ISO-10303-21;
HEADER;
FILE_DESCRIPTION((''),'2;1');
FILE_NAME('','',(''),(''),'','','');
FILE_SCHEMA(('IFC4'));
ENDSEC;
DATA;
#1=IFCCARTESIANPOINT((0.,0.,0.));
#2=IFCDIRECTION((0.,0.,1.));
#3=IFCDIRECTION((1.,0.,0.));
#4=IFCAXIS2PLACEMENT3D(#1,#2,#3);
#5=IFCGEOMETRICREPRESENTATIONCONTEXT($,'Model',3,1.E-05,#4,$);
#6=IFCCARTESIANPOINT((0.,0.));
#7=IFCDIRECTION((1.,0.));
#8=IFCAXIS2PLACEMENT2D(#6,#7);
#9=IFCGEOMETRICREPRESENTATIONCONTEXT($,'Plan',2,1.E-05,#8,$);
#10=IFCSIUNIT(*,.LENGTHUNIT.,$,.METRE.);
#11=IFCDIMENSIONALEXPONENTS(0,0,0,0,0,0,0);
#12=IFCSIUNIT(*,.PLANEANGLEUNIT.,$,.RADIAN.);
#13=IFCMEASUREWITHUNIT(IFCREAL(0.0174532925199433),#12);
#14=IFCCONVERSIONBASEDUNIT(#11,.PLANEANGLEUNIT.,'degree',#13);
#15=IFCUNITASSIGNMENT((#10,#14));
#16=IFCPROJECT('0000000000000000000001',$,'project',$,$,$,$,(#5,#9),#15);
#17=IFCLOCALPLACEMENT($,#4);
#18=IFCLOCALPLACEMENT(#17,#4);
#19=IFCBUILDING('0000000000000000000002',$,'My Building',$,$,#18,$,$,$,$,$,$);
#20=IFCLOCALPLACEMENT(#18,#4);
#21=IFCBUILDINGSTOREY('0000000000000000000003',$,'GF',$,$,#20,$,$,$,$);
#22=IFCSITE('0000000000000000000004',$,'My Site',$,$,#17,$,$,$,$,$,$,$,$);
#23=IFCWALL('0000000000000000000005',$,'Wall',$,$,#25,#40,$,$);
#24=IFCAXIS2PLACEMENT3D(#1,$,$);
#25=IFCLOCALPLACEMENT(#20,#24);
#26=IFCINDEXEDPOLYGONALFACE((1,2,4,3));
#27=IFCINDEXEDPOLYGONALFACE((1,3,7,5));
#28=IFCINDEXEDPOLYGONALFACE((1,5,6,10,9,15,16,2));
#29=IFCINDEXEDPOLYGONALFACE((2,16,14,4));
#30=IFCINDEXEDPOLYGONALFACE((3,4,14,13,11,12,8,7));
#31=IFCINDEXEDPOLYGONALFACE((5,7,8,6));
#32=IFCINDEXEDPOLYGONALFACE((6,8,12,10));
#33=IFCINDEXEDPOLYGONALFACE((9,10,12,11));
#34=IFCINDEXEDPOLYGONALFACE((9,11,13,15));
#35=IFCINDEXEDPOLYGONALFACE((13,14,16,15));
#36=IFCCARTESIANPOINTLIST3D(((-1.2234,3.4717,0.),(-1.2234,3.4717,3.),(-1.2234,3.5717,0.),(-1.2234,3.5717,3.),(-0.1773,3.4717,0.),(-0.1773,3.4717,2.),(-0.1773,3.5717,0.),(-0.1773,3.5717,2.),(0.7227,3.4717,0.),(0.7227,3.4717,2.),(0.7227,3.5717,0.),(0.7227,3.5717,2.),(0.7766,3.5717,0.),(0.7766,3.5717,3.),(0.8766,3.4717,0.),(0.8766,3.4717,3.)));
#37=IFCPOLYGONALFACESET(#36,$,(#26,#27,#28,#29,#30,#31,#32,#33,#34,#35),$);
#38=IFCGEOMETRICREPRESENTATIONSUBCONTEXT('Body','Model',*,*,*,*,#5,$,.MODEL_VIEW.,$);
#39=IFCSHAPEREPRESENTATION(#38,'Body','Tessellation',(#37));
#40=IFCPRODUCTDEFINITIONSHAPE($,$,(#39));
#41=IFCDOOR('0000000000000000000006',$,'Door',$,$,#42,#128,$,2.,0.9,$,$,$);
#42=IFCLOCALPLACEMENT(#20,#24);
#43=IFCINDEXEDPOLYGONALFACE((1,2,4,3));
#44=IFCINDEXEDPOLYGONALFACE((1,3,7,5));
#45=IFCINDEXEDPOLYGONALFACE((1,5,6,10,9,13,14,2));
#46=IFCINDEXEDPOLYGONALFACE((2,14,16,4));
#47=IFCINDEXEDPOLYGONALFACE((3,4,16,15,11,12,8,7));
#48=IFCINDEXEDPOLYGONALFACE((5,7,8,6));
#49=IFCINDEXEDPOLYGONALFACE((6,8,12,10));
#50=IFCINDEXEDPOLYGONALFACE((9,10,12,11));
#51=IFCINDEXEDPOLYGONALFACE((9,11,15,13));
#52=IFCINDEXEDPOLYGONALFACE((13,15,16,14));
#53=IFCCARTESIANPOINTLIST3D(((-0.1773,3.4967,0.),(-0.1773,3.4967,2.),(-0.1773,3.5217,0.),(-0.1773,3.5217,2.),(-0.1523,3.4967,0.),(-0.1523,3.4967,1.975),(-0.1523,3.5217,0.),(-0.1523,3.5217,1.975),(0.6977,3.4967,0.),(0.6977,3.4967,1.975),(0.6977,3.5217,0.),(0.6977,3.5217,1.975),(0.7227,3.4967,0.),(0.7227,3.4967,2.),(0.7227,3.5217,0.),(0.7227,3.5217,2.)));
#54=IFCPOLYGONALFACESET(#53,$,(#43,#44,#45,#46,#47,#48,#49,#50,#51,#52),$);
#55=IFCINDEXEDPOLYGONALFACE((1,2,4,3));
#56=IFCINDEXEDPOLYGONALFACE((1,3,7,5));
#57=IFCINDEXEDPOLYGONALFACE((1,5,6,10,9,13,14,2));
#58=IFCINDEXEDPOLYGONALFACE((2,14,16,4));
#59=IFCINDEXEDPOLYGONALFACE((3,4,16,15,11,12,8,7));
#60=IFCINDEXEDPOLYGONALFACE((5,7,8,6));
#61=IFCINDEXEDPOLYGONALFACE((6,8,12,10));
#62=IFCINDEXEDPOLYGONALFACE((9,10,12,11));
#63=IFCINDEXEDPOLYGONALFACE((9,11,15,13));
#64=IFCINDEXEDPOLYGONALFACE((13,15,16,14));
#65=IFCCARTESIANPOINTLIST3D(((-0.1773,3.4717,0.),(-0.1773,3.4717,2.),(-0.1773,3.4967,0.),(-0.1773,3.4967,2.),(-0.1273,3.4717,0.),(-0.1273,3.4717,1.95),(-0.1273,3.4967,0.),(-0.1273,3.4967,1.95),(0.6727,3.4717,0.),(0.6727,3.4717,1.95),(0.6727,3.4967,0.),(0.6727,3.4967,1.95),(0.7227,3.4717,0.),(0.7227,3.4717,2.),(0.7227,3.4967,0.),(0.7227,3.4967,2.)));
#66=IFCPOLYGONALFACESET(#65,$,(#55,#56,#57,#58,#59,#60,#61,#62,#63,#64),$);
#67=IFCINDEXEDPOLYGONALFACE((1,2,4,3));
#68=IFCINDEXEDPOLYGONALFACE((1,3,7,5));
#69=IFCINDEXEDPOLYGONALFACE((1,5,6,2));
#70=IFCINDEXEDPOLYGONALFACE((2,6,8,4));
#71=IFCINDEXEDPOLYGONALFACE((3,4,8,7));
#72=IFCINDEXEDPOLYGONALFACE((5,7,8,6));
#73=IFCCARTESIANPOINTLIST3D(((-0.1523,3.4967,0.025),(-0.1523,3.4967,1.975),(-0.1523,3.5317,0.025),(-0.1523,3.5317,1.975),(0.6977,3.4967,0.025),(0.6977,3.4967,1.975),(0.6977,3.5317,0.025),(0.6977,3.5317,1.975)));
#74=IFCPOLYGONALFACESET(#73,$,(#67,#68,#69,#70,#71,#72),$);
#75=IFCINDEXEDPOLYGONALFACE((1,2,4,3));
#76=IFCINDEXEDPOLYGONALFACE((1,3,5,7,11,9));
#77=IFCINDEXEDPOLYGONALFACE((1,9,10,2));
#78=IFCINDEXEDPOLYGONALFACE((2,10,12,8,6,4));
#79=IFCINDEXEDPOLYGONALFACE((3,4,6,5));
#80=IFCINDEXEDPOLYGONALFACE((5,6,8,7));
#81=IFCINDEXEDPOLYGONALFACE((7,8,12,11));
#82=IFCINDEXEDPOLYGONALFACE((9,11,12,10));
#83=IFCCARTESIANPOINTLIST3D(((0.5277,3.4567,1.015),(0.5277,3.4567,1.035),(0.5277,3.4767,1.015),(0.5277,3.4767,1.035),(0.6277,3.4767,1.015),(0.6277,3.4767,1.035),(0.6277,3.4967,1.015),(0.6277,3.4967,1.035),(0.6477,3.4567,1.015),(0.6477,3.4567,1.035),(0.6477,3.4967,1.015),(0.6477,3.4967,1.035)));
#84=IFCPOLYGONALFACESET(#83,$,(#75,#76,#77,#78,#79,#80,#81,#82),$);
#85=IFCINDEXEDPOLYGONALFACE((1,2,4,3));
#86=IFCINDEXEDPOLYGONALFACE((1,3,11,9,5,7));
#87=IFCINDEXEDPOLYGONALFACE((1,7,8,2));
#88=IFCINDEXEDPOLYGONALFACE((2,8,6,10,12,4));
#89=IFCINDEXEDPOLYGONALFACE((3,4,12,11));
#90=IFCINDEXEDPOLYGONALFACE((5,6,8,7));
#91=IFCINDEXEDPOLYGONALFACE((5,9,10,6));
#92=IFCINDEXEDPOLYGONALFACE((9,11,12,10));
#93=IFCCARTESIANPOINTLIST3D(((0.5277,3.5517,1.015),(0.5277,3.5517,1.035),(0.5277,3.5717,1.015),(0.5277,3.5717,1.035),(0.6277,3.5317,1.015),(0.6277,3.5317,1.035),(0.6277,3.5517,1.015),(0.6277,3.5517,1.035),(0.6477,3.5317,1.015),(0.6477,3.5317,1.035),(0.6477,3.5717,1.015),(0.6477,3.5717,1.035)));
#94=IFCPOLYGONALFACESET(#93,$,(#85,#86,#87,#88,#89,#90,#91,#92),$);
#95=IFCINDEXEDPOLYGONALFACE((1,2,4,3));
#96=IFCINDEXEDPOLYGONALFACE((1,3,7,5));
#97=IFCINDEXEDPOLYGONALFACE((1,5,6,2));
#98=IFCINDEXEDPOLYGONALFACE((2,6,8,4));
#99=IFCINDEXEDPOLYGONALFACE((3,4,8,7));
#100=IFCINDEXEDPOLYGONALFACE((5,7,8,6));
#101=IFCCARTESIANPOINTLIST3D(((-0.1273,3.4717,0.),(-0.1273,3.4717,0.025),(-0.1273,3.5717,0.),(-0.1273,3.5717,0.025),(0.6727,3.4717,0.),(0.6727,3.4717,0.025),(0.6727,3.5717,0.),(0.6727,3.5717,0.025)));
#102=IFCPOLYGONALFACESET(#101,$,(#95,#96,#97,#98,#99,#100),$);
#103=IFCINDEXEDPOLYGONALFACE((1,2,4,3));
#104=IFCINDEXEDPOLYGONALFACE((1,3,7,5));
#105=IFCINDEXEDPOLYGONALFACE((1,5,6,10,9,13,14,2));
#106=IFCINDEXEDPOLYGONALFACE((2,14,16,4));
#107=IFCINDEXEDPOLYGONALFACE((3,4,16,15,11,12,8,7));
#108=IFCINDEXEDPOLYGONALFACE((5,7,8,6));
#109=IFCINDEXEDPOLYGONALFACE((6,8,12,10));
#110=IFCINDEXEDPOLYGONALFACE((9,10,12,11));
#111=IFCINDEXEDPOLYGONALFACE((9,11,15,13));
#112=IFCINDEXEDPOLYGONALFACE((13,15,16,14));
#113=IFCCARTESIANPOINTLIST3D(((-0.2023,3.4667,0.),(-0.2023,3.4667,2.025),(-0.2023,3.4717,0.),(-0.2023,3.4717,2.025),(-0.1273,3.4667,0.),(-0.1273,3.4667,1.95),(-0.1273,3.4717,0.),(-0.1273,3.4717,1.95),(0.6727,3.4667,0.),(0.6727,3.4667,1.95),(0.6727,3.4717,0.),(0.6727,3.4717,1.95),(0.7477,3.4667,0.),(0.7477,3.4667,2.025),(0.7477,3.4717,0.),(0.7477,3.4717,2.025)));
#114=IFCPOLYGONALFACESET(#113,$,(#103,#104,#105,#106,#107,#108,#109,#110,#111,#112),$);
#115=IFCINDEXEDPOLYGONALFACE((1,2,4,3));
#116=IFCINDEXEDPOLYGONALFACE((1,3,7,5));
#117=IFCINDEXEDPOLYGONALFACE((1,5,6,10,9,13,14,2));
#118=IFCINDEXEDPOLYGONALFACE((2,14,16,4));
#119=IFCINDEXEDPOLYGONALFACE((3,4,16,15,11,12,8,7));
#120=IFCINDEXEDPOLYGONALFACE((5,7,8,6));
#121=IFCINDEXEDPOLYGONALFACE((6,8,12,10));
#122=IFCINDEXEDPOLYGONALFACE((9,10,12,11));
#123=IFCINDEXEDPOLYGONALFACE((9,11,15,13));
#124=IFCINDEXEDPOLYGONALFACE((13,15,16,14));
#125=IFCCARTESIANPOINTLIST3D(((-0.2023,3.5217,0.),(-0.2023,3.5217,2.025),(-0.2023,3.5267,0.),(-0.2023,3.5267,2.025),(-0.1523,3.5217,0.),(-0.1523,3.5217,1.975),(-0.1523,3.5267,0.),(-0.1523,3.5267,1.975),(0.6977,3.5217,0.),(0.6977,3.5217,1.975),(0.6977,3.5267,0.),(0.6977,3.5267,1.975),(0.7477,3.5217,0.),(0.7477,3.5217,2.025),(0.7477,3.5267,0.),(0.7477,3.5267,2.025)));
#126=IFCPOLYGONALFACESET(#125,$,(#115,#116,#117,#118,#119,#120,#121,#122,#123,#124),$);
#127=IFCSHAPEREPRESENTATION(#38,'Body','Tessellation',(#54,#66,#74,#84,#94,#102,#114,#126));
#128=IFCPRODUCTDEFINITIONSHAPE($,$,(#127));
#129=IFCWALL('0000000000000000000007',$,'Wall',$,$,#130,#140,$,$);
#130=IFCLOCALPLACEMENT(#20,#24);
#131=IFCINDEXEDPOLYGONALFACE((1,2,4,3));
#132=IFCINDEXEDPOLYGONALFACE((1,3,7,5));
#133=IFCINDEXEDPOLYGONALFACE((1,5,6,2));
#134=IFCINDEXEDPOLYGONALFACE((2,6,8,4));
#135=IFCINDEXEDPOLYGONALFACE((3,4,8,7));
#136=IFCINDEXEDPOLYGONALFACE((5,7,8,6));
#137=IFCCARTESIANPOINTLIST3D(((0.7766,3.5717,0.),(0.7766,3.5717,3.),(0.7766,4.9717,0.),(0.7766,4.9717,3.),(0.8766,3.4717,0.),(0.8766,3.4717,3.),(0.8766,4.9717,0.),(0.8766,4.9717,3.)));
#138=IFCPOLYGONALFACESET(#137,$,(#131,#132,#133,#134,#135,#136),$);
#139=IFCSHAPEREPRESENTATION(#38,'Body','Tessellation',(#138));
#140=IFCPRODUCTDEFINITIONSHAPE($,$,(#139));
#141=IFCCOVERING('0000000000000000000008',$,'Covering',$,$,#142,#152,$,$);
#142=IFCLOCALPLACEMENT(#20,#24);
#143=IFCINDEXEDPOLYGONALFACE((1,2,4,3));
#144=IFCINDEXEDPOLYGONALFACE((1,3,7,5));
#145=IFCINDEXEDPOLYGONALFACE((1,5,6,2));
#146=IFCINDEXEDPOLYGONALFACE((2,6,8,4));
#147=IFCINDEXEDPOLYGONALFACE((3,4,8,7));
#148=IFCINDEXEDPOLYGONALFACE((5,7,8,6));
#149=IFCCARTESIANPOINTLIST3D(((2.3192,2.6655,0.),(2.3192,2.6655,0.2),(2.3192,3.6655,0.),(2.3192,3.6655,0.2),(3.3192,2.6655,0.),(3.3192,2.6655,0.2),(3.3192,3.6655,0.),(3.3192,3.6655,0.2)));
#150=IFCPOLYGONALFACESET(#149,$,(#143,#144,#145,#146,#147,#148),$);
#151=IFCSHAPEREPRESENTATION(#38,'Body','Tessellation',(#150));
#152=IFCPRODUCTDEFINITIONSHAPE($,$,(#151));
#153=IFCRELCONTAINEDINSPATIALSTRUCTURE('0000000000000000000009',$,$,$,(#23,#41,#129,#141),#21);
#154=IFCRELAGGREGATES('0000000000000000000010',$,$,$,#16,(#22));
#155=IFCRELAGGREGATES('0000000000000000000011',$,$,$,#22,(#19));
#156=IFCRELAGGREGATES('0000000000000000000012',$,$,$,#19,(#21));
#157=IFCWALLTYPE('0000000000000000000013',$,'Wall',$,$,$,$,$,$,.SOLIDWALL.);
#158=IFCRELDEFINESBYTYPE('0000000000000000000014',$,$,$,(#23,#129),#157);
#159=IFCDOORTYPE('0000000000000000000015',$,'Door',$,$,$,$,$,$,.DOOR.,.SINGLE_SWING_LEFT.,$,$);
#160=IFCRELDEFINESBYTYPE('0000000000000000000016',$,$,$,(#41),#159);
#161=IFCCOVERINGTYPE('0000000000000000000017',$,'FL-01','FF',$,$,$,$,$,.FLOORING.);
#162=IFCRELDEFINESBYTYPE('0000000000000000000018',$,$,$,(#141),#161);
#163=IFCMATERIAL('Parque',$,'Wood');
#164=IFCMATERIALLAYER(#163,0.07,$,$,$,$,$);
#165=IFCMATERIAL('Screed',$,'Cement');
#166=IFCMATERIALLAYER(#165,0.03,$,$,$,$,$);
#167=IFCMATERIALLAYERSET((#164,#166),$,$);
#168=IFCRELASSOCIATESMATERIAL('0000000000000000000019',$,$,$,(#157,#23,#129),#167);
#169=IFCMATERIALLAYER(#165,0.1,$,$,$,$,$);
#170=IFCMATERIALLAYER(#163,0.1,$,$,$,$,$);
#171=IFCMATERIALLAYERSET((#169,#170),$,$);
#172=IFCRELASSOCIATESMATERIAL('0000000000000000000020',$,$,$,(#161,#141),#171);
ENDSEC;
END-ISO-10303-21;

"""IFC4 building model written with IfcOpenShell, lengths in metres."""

from ifc_helpers import new_model, entity, si_unit, converted_unit, frame, origin_with_axes, origin_2d_with_axis, place, context, subcontext, project, spatial, line, indexed_curve, outline, extrude, shape, source, transform, mapped, material, layer, layer_set, layer_usage, type_object, type_shapes, element, fill, save


model = new_model("IFC4")

# Units and contexts
model_context = context("Model", 3, precision=1e-05, world=origin_with_axes())
plan_context = context("Plan", 2, precision=1e-05, world=origin_2d_with_axis())
body_context_1 = subcontext(model_context, "Body", "Model", "MODEL_VIEW")
body_context_2 = subcontext(plan_context, "Body", "Plan", "PLAN_VIEW")
ifc_project = project(units=[si_unit("LENGTHUNIT", "METRE"), converted_unit("PLANEANGLEUNIT", "degree", entity("IfcReal", 0.0174532925199433), si_unit("PLANEANGLEUNIT", "RADIAN"), dimensions=[0, 0, 0, 0, 0, 0, 0])], contexts=[model_context, plan_context])

# Site, building, storey
site_placement = place(None, origin_with_axes())
site = spatial("IfcSite", under=ifc_project, at=site_placement, Name="My Site")
building_placement = place(site_placement, origin_with_axes())
building = spatial("IfcBuilding", under=site, at=building_placement, Name="My Building")
storey_placement = place(building_placement, origin_with_axes())
storey = spatial("IfcBuildingStorey", under=building, at=storey_placement, Name="GF")

# Shared definitions
ifc_material_1 = material(Name="Parque", Category="Wood")
ifc_layer_1 = layer(ifc_material_1, 0.07)
ifc_material_2 = material(Name="Screed", Category="Cement")
ifc_layer_2 = layer(ifc_material_2, 0.03)
ifc_layer_set_1 = layer_set([ifc_layer_1, ifc_layer_2])
wall_type = type_object("IfcWallType", Name="Wall", PredefinedType="SOLIDWALL", material=ifc_layer_set_1)

# Shared definitions
shared_shape_1 = source(origin_with_axes(), body_context_1, "Body", "SweptSolid", [
    extrude(outline(indexed_curve([(0.0, 0.0), (0.9, 0.0), (0.9, 2.0), (0.0, 2.0)], segments=[line(1, 2, 3, 4, 1)])), frame((0.0, -0.6, 0.0), z_axis=(0.0, -1.0, 0.0), x_axis=(1.0, 0.0, 0.0)), (0.0, 0.0, -1.0), 1.2),
])
door_type = type_object("IfcDoorType", Name="Door", OperationType="SINGLE_SWING_LEFT", PredefinedType="DOOR")
shared_shape_2 = source(origin_with_axes(), body_context_1, "Body", "SweptSolid", [
    extrude(outline(indexed_curve([(0.0, 0.0), (0.0, 2.0), (0.9, 2.0), (0.9, 0.0), (0.875, 0.0), (0.875, 1.975), (0.025, 1.975), (0.025, 0.0)], segments=[line(1, 2, 3, 4, 5, 6, 7, 8, 1)])), frame((0.0, 0.025, 0.0), z_axis=(0.0, -1.0, 0.0), x_axis=(1.0, 0.0, 0.0)), (0.0, 0.0, -1.0), 0.025),
    extrude(outline(indexed_curve([(0.0, 0.0), (0.0, 2.0), (0.9, 2.0), (0.9, 0.0), (0.85, 0.0), (0.85, 1.95), (0.05, 1.95), (0.05, 0.0)], segments=[line(1, 2, 3, 4, 5, 6, 7, 8, 1)])), frame((0.0, 0.0, 0.0), z_axis=(0.0, -1.0, 0.0), x_axis=(1.0, 0.0, 0.0)), (0.0, 0.0, -1.0), 0.025),
    extrude(outline(indexed_curve([(0.0, 0.0), (0.85, 0.0), (0.85, 0.035), (0.0, 0.035)], segments=[line(1, 2, 3, 4, 1)])), frame((0.025, 0.025, 0.025), z_axis=(0.0, 0.0, 1.0), x_axis=(1.0, 0.0, 0.0)), (0.0, 0.0, 1.0), 1.95),
    extrude(outline(indexed_curve([(0.0, 0.0), (0.0, -0.04), (-0.12, -0.04), (-0.12, -0.02), (-0.02, -0.02), (-0.02, 0.0)], segments=[line(1, 2, 3, 4, 5, 6, 1)])), frame((0.825, 0.025, 1.015), z_axis=(0.0, 0.0, 1.0), x_axis=(1.0, 0.0, 0.0)), (0.0, 0.0, 1.0), 0.02),
    extrude(outline(indexed_curve([(0.0, 0.0), (0.0, 0.04), (-0.12, 0.04), (-0.12, 0.02), (-0.02, 0.02), (-0.02, 0.0)], segments=[line(1, 2, 3, 4, 5, 6, 1)])), frame((0.825, 0.06, 1.015), z_axis=(0.0, 0.0, 1.0), x_axis=(1.0, 0.0, 0.0)), (0.0, 0.0, 1.0), 0.02),
    extrude(outline(indexed_curve([(0.0, 0.0), (0.8, 0.0), (0.8, 0.1), (0.0, 0.1)], segments=[line(1, 2, 3, 4, 1)])), frame((0.05, 0.0, 0.0), z_axis=(0.0, 0.0, 1.0), x_axis=(1.0, 0.0, 0.0)), (0.0, 0.0, 1.0), 0.025),
    extrude(outline(indexed_curve([(0.0, 0.0), (0.0, 2.025), (0.95, 2.025), (0.95, 0.0), (0.875, 0.0), (0.875, 1.95), (0.075, 1.95), (0.075, 0.0)], segments=[line(1, 2, 3, 4, 5, 6, 7, 8, 1)])), frame((-0.025, -0.005, 0.0), z_axis=(0.0, -1.0, 0.0), x_axis=(1.0, 0.0, 0.0)), (0.0, 0.0, -1.0), 0.005),
    extrude(outline(indexed_curve([(0.0, 0.0), (0.0, 2.025), (0.95, 2.025), (0.95, 0.0), (0.9, 0.0), (0.9, 1.975), (0.05, 1.975), (0.05, 0.0)], segments=[line(1, 2, 3, 4, 5, 6, 7, 8, 1)])), frame((-0.025, 0.05, 0.0), z_axis=(0.0, -1.0, 0.0), x_axis=(1.0, 0.0, 0.0)), (0.0, 0.0, -1.0), 0.005),
])
shared_shape_3 = source(origin_with_axes(), body_context_2, "Body", "Curve2D", [
    entity("IfcIndexedPolyCurve", entity("IfcCartesianPointList2D", [[0.0, 0.0], [0.0, 0.05], [0.025, 0.05], [0.025, 0.025], [0.05, 0.025], [0.05, 0.0]]), [entity("IfcLineIndex", [1, 2, 3, 4, 5, 6, 1])]),
    entity("IfcIndexedPolyCurve", entity("IfcCartesianPointList2D", [[0.9, 0.0], [0.9, 0.05], [0.875, 0.05], [0.875, 0.025], [0.85, 0.025], [0.85, 0.0]]), [entity("IfcLineIndex", [1, 2, 3, 4, 5, 6, 1])]),
    entity("IfcTrimmedCurve", entity("IfcEllipse", entity("IfcAxis2Placement2D", entity("IfcCartesianPoint", [0.06, 0.05]), entity("IfcDirection", [1.0, 0.0])), 0.815, 0.85), [entity("IfcCartesianPoint", [0.875, 0.05])], [entity("IfcCartesianPoint", [0.06, 0.9])], True, "CARTESIAN"),
    entity("IfcIndexedPolyCurve", entity("IfcCartesianPointList2D", [[0.025, 0.05], [0.06, 0.05], [0.06, 0.9], [0.025, 0.9]]), [entity("IfcLineIndex", [1, 2, 3, 4, 1])]),
])
type_shapes(door_type, [shared_shape_2, shared_shape_3])

# Wall, opening, door
ifc_layer_usage_1 = layer_usage(ifc_layer_set_1, "AXIS2", "POSITIVE", 0.0)
wall_1_placement = place(storey_placement, frame((-1.2234, 3.4717, 0.0), z_axis=(0.0, 0.0, 1.0), x_axis=(1.0, 0.0, 0.0)))
wall_1 = element("IfcWall", 1, at=wall_1_placement, inside=storey, type_object=wall_type, material=ifc_layer_usage_1, Name="Wall", context=body_context_1, shape_type="SweptSolid", body=[
    extrude(outline(indexed_curve([(0.0, 0.0), (0.0, 0.1), (2.0, 0.1), (2.1, 0.0)], segments=[line(1, 2, 3, 4, 1)])), origin_with_axes(), (0.0, 0.0, 1.0), 3.0),
])
opening_1_placement = place(wall_1_placement, frame((1.046, 0.0, 0.0), z_axis=(0.0, 0.0, 1.0), x_axis=(1.0, 0.0, 0.0)))
opening_1 = element("IfcOpeningElement", 2, at=opening_1_placement, cuts=wall_1, PredefinedType="OPENING", context=body_context_1, shape_type="MappedRepresentation", body=[
    mapped(shared_shape_1, transform((0.0, 0.0, 0.0), x_axis=(1.0, 0.0, 0.0), y_axis=(0.0, 1.0, 0.0), z_axis=(0.0, 0.0, 1.0), scale=1.0)),
])
door_1_placement = place(opening_1_placement, origin_with_axes())
door_1 = element("IfcDoor", 3, at=door_1_placement, inside=storey, type_object=door_type, Name="Door", OverallHeight=2.0, OverallWidth=0.9, shapes=[
    shape(body_context_1, "Body", "MappedRepresentation", [mapped(shared_shape_2, transform((0.0, 0.0, 0.0), x_axis=(1.0, 0.0, 0.0), y_axis=(0.0, 1.0, 0.0), z_axis=(0.0, 0.0, 1.0), scale=1.0))]),
    shape(body_context_2, "Body", "MappedRepresentation", [mapped(shared_shape_3, transform((0.0, 0.0, 0.0), x_axis=(1.0, 0.0, 0.0), y_axis=(0.0, 1.0, 0.0), z_axis=(0.0, 0.0, 1.0), scale=1.0))]),
])
fill(opening_1, door_1)

# Wall
ifc_layer_usage_2 = layer_usage(ifc_layer_set_1, "AXIS2", "POSITIVE", 0.0)
wall_2_placement = place(storey_placement, frame((0.8766, 3.4717, 0.0), z_axis=(0.0, 0.0, 1.0), x_axis=(0.0, 1.0, 0.0)))
element("IfcWall", 4, at=wall_2_placement, inside=storey, type_object=wall_type, material=ifc_layer_usage_2, Name="Wall", context=body_context_1, shape_type="SweptSolid", body=[
    extrude(outline(indexed_curve([(0.0, 0.0), (0.1, 0.1), (1.5, 0.1), (1.5, 0.0)], segments=[line(1, 2, 3, 4, 1)])), origin_with_axes(), (0.0, 0.0, 1.0), 3.0),
])

# Covering
ifc_layer_3 = layer(ifc_material_2, 0.1)
ifc_layer_4 = layer(ifc_material_1, 0.1)
ifc_layer_set_2 = layer_set([ifc_layer_3, ifc_layer_4])
ifc_layer_usage_3 = layer_usage(ifc_layer_set_2, "AXIS3", "POSITIVE", 0.0)
covering_type = type_object("IfcCoveringType", Name="FL-01", Description="FF", PredefinedType="FLOORING", material=ifc_layer_set_2)
covering_1_placement = place(storey_placement, frame((2.3192, 2.6655, 0.0), z_axis=(0.0, 0.0, 1.0), x_axis=(1.0, 0.0, 0.0)))
element("IfcCovering", 5, at=covering_1_placement, inside=storey, type_object=covering_type, material=ifc_layer_usage_3, Name="Covering", context=body_context_1, shape_type="SweptSolid", body=[
    extrude(outline(indexed_curve([(0.0, 0.0), (1.0, 0.0), (1.0, 1.0), (0.0, 1.0), (0.0, 0.0)])), None, (0.0, 0.0, 1.0), 0.2),
])

save(model, "model.ifc")
